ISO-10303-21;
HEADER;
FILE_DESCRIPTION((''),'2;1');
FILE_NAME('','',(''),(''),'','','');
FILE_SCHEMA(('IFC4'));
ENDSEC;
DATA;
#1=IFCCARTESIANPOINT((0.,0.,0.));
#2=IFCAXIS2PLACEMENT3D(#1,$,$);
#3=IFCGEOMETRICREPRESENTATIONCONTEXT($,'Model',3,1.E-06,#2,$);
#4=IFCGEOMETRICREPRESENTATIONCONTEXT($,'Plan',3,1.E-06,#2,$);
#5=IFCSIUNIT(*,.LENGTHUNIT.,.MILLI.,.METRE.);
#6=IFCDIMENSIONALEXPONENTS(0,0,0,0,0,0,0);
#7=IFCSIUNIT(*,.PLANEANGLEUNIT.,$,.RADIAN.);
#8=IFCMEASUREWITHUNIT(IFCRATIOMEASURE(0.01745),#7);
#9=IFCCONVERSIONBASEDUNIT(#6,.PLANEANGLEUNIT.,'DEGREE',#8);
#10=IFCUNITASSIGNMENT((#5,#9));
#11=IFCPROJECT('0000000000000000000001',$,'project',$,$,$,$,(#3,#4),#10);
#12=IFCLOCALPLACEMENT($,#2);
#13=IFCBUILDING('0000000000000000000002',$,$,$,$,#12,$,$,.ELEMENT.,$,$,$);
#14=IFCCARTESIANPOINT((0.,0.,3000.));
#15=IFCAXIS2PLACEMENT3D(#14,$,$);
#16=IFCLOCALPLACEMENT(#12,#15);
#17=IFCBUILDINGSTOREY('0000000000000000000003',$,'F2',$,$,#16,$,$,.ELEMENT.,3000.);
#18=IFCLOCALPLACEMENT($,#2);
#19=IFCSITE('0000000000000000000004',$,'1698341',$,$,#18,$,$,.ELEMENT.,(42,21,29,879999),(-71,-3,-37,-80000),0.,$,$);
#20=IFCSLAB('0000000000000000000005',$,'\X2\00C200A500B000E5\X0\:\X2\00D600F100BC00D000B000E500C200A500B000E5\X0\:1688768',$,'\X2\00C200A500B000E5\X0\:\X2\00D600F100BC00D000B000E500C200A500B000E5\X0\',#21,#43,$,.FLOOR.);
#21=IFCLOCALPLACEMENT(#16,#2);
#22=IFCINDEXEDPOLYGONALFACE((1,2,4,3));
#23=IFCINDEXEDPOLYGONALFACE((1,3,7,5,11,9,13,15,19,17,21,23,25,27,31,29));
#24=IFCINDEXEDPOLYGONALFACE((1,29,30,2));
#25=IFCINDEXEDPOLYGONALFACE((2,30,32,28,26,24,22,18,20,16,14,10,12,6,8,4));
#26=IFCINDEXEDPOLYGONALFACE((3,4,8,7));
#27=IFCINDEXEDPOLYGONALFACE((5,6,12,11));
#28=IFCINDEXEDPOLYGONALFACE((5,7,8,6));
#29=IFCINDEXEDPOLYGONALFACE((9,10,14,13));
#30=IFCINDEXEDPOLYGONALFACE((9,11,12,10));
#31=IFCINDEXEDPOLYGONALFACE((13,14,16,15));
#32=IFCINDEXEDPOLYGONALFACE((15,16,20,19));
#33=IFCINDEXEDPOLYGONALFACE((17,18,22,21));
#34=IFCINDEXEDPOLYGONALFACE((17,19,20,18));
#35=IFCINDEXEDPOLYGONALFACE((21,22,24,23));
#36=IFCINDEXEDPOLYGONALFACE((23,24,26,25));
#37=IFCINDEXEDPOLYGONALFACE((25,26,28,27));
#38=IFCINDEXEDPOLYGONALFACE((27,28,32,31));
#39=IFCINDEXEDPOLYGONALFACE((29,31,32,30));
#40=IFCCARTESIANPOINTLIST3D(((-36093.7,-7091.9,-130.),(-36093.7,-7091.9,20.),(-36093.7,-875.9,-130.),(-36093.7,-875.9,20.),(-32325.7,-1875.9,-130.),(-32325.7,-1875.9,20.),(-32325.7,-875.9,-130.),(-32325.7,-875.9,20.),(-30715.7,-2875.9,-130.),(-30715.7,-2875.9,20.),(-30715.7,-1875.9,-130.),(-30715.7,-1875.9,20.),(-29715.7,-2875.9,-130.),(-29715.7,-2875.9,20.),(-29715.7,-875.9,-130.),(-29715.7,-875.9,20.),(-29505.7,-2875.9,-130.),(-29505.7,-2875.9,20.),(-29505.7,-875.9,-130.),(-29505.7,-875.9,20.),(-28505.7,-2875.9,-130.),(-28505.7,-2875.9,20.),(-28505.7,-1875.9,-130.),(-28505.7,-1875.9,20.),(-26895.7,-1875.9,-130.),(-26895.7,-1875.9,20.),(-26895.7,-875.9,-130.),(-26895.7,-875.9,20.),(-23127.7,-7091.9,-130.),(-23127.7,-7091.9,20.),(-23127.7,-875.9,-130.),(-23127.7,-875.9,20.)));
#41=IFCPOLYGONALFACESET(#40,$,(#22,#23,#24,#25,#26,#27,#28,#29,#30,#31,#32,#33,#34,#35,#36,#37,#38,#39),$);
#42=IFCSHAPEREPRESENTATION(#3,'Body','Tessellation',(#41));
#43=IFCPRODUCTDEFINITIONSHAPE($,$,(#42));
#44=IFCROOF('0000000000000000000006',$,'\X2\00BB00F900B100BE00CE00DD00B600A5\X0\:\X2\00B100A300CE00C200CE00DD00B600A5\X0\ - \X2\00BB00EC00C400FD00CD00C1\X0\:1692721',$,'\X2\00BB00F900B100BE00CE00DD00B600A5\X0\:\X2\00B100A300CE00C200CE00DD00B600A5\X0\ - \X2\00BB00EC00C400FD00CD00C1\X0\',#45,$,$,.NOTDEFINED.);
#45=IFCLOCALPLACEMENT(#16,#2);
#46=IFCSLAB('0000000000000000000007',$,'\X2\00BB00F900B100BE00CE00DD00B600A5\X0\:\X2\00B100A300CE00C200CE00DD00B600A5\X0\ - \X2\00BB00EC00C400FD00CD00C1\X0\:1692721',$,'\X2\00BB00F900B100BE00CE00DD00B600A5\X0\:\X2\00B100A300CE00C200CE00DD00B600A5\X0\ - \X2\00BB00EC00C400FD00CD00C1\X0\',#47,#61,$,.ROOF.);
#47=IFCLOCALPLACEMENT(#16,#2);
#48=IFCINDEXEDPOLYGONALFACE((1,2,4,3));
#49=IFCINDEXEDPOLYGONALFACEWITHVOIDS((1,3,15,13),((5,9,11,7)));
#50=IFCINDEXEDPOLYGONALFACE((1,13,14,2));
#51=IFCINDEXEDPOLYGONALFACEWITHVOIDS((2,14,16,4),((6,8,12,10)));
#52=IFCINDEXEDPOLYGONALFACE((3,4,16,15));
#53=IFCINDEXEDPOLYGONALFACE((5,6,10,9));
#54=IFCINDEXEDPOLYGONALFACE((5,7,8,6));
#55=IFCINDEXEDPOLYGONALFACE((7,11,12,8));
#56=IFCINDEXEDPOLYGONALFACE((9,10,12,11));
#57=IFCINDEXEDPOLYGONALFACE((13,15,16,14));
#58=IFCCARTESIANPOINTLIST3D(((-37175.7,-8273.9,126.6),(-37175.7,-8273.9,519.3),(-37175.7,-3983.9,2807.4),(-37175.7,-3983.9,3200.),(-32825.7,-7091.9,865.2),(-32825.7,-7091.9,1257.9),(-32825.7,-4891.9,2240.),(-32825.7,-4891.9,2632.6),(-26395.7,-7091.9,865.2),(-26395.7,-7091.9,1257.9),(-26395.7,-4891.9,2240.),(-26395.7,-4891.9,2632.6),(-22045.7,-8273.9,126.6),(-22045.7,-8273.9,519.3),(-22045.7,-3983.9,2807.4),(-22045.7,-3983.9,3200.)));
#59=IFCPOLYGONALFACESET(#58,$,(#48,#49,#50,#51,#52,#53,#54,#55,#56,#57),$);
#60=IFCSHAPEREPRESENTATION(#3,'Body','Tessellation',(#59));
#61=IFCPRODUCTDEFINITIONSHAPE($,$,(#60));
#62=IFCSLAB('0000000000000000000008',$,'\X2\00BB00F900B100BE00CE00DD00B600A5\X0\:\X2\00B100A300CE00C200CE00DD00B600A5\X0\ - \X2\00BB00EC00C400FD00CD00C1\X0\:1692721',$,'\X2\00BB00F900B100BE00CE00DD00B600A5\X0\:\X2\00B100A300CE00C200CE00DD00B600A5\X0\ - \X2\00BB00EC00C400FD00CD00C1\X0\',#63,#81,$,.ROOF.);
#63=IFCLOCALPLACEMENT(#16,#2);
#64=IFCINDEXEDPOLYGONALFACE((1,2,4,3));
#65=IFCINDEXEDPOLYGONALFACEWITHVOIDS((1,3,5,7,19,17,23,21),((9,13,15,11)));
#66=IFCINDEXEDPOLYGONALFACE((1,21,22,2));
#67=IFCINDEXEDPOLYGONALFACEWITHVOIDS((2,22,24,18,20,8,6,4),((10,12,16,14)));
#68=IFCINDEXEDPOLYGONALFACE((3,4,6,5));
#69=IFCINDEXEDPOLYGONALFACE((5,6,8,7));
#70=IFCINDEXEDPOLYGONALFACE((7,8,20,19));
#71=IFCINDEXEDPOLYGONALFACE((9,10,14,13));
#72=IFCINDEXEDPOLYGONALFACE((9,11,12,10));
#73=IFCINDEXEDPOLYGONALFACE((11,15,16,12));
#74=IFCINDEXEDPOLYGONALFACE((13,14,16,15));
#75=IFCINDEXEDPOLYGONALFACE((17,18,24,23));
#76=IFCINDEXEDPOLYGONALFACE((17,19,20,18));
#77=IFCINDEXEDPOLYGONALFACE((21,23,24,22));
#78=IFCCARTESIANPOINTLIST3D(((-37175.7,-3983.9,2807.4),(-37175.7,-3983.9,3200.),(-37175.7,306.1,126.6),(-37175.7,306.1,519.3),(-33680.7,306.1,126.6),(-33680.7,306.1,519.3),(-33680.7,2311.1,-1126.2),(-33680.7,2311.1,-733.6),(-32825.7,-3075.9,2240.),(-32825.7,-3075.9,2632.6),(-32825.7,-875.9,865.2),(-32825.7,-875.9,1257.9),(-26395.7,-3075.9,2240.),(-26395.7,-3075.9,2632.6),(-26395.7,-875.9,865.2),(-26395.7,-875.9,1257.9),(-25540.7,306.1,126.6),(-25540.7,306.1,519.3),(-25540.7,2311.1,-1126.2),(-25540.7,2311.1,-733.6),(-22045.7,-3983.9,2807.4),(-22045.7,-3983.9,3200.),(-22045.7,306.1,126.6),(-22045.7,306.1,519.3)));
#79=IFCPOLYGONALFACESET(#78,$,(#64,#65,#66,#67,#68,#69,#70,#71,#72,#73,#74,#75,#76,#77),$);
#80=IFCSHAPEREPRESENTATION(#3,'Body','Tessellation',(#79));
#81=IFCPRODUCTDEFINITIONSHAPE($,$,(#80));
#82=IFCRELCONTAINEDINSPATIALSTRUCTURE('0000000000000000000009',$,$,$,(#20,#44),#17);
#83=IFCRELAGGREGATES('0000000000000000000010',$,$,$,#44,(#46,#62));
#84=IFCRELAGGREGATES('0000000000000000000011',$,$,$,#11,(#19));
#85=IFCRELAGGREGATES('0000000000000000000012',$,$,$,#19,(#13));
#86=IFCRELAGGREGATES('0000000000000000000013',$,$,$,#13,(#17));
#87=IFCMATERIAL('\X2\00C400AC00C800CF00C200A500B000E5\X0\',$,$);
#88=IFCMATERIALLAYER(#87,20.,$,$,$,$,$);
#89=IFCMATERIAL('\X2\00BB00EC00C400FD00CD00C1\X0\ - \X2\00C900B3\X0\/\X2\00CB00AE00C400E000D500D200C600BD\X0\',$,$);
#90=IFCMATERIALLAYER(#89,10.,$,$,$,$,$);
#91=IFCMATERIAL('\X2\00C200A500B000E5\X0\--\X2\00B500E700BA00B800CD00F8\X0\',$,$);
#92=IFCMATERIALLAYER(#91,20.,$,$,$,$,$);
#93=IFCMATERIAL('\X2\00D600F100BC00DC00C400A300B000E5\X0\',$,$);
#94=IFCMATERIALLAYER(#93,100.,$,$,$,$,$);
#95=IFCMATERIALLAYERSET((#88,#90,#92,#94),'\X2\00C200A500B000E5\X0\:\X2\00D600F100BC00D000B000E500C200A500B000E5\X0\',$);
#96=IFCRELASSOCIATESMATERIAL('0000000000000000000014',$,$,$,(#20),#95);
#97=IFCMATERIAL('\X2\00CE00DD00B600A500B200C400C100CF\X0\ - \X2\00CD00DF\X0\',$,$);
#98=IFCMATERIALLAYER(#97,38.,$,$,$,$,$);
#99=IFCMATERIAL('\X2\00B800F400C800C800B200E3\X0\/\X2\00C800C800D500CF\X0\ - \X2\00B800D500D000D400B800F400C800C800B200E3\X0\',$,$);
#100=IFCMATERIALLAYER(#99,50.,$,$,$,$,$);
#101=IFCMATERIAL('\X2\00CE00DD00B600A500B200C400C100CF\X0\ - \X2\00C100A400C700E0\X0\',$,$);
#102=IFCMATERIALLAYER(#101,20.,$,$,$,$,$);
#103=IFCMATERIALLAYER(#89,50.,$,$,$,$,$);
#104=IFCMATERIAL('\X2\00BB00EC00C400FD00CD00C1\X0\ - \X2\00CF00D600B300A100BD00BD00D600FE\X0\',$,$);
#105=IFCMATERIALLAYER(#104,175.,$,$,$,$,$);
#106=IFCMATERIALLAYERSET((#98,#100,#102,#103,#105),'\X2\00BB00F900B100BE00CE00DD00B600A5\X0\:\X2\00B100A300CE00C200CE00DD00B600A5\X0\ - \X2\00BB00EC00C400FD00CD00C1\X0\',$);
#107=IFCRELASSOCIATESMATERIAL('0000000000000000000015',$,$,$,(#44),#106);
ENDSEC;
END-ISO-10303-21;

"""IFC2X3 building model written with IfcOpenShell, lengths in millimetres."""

from ifc_helpers import new_model, entity, si_unit, converted_unit, frame, frame_2d, origin, origin_2d_with_axis, place, context, project, spatial, polyline, rectangle, outline, extrude, material, layer, layer_set, layer_usage, element, aggregate, save


model = new_model("IFC2X3")

# Units and contexts
model_context = context("Model", 3, precision=1e-06, world=origin())
plan_context = context("Plan", 3, precision=1e-06, world=origin())
ifc_project = project(units=[si_unit("LENGTHUNIT", "METRE", prefix="MILLI"), converted_unit("PLANEANGLEUNIT", "DEGREE", entity("IfcRatioMeasure", 0.01745), si_unit("PLANEANGLEUNIT", "RADIAN"), dimensions=[0, 0, 0, 0, 0, 0, 0])], contexts=[model_context, plan_context])

# Site, building, storey
site_placement = place(None, origin())
site = spatial("IfcSite", under=ifc_project, at=site_placement, Name="1698341", CompositionType="ELEMENT", RefLatitude=(42, 21, 29, 879999), RefLongitude=(-71, -3, -37, -80000), RefElevation=0.0)
building_placement = place(None, origin())
building = spatial("IfcBuilding", under=site, at=building_placement, CompositionType="ELEMENT")
storey_placement = place(building_placement, frame((0.0, 0.0, 3000.0)))
storey = spatial("IfcBuildingStorey", under=building, at=storey_placement, Name="F2", CompositionType="ELEMENT", Elevation=3000.0)

# Slab, openings
ifc_material_1 = material(Name="Ä¬ÈÏÂ¥°å")
ifc_layer_1 = layer(ifc_material_1, 20.0)
ifc_material_2 = material(Name="»ìÄýÍÁ - É³/Ë®ÄàÕÒÆ½")
ifc_layer_2 = layer(ifc_material_2, 10.0)
ifc_material_3 = material(Name="Â¥°å--µçº¸Íø")
ifc_layer_3 = layer(ifc_material_3, 20.0)
ifc_material_4 = material(Name="Öñ¼ÜÄ£°å")
ifc_layer_4 = layer(ifc_material_4, 100.0)
ifc_layer_set_1 = layer_set([ifc_layer_1, ifc_layer_2, ifc_layer_3, ifc_layer_4], Name="Â¥°å:Öñ¼Ð°åÂ¥°å")
ifc_layer_usage_1 = layer_usage(ifc_layer_set_1, "AXIS3", "POSITIVE", 0.0)
slab_1_placement = place(storey_placement, frame((-36093.7, -7091.9, -130.0)))
slab_1 = element("IfcSlab", 1, at=slab_1_placement, inside=storey, material=ifc_layer_usage_1, Name="Â¥°å:Öñ¼Ð°åÂ¥°å:1688768", ObjectType="Â¥°å:Öñ¼Ð°åÂ¥°å", PredefinedType="FLOOR", context=model_context, shape_type="SweptSolid", body=[
    extrude(rectangle(XDim=6216.0, YDim=12966.0, at=frame_2d((0.0, 0.0), x_axis=(0.0, -1.0))), frame((6483.0, 3108.0, 150.0), z_axis=(0.0, 0.0, -1.0), x_axis=(-1.0, 0.0, 0.0)), (0.0, 0.0, 1.0), 150.0),
])
opening_1_placement = place(storey_placement, frame((-36093.7, -7091.9, -130.0)))
element("IfcOpeningElement", 2, at=opening_1_placement, cuts=slab_1, ObjectType="Opening", context=model_context, shape_type="SweptSolid", body=[
    extrude(outline(polyline([(2715.0, 3108.0), (105.0, 3108.0), (105.0, 1108.0), (1105.0, 1108.0), (1105.0, 2108.0), (2715.0, 2108.0), (2715.0, 3108.0)])), frame((6483.0, 3108.0, 150.0), z_axis=(0.0, 0.0, -1.0), x_axis=(-1.0, 0.0, 0.0)), (0.0, 0.0, 1.0), 150.0),
])
opening_2_placement = place(storey_placement, frame((-36093.7, -7091.9, -130.0)))
element("IfcOpeningElement", 3, at=opening_2_placement, cuts=slab_1, ObjectType="Opening", context=model_context, shape_type="SweptSolid", body=[
    extrude(outline(polyline([(-2715.0, 3108.0), (-2715.0, 2108.0), (-1105.0, 2108.0), (-1105.0, 1108.0), (-105.0, 1108.0), (-105.0, 3108.0), (-2715.0, 3108.0)])), frame((6483.0, 3108.0, 150.0), z_axis=(0.0, 0.0, -1.0), x_axis=(-1.0, 0.0, 0.0)), (0.0, 0.0, 1.0), 150.0),
])

# Roof, slabs, openings
ifc_material_5 = material(Name="ÎÝ¶¥²ÄÁÏ - Íß")
ifc_layer_5 = layer(ifc_material_5, 38.0)
ifc_material_6 = material(Name="¸ôÈÈ²ã/ÈÈÕÏ - ¸ÕÐÔ¸ôÈÈ²ã")
ifc_layer_6 = layer(ifc_material_6, 50.0)
ifc_material_7 = material(Name="ÎÝ¶¥²ÄÁÏ - Á¤Çà")
ifc_layer_7 = layer(ifc_material_7, 20.0)
ifc_layer_8 = layer(ifc_material_2, 50.0)
ifc_material_8 = material(Name="»ìÄýÍÁ - ÏÖ³¡½½Öþ")
ifc_layer_9 = layer(ifc_material_8, 175.0)
ifc_layer_set_2 = layer_set([ifc_layer_5, ifc_layer_6, ifc_layer_7, ifc_layer_8, ifc_layer_9], Name="»ù±¾ÎÝ¶¥:±£ÎÂÎÝ¶¥ - »ìÄýÍÁ")
ifc_layer_usage_2 = layer_usage(ifc_layer_set_2, "AXIS3", "NEGATIVE", 0.0)
roof_placement = place(storey_placement, origin())
roof = element("IfcRoof", 4, at=roof_placement, inside=storey, material=ifc_layer_usage_2, Name="»ù±¾ÎÝ¶¥:±£ÎÂÎÝ¶¥ - »ìÄýÍÁ:1692721", ObjectType="»ù±¾ÎÝ¶¥:±£ÎÂÎÝ¶¥ - »ìÄýÍÁ", ShapeType="NOTDEFINED")
slab_2_placement = place(roof_placement, frame((-37175.7, -8273.9, -1126.2)))
slab_2 = element("IfcSlab", 5, at=slab_2_placement, Name="»ù±¾ÎÝ¶¥:±£ÎÂÎÝ¶¥ - »ìÄýÍÁ:1692721", ObjectType="»ù±¾ÎÝ¶¥:±£ÎÂÎÝ¶¥ - »ìÄýÍÁ", PredefinedType="ROOF", context=model_context, shape_type="SweptSolid", body=[
    extrude(rectangle(XDim=5058.7, YDim=15130.0, at=frame_2d((0.0, 0.0), x_axis=(0.0, -1.0))), frame((7565.0, 2145.0, 2593.2), z_axis=(0.0, -0.5299, 0.848), x_axis=(1.0, 0.0, 0.0)), (0.0, 0.5299, 0.848), 392.7),
])
opening_3_placement = place(roof_placement, frame((-37175.7, -8273.9, -1126.2)))
element("IfcOpeningElement", 6, at=opening_3_placement, cuts=slab_2, ObjectType="Opening", context=model_context, shape_type="SweptSolid", body=[
    extrude(rectangle(XDim=2594.2, YDim=6430.0, at=frame_2d((0.0, 0.0), x_axis=(0.0, 1.0))), frame((7565.0, 2282.0, 2678.8), z_axis=(0.0, -0.5299, 0.848), x_axis=(-1.0, 0.0, 0.0)), (0.0, -0.5299, 0.848), 392.7),
])
slab_3_placement = place(roof_placement, frame((-37175.7, -8273.9, -1126.2)))
slab_3 = element("IfcSlab", 7, at=slab_3_placement, Name="»ù±¾ÎÝ¶¥:±£ÎÂÎÝ¶¥ - »ìÄýÍÁ:1692721", ObjectType="»ù±¾ÎÝ¶¥:±£ÎÂÎÝ¶¥ - »ìÄýÍÁ", PredefinedType="ROOF", context=model_context, shape_type="SweptSolid", body=[
    extrude(outline(polyline([(-7565.0, -3711.5), (7565.0, -3711.5), (7565.0, 1347.2), (4070.0, 1347.2), (4070.0, 3711.5), (-4070.0, 3711.5), (-4070.0, 1347.2), (-7565.0, 1347.2), (-7565.0, -3711.5)])), frame((7565.0, 7437.5, 1966.8), z_axis=(0.0, 0.5299, 0.848), x_axis=(1.0, 0.0, 0.0)), (0.0, -0.5299, 0.848), 392.7),
])
opening_4_placement = place(roof_placement, frame((-37175.7, -8273.9, -1126.2)))
element("IfcOpeningElement", 8, at=opening_4_placement, cuts=slab_3, ObjectType="Opening", context=model_context, shape_type="SweptSolid", body=[
    extrude(rectangle(XDim=2594.2, YDim=6430.0, at=origin_2d_with_axis()), frame((7565.0, 6298.0, 2678.8), z_axis=(0.0, 0.5299, 0.848), x_axis=(0.0, 0.848, -0.5299)), (-0.5299, 0.0, 0.848), 392.7),
])
aggregate(roof, [slab_2, slab_3])

save(model, "model.ifc")
